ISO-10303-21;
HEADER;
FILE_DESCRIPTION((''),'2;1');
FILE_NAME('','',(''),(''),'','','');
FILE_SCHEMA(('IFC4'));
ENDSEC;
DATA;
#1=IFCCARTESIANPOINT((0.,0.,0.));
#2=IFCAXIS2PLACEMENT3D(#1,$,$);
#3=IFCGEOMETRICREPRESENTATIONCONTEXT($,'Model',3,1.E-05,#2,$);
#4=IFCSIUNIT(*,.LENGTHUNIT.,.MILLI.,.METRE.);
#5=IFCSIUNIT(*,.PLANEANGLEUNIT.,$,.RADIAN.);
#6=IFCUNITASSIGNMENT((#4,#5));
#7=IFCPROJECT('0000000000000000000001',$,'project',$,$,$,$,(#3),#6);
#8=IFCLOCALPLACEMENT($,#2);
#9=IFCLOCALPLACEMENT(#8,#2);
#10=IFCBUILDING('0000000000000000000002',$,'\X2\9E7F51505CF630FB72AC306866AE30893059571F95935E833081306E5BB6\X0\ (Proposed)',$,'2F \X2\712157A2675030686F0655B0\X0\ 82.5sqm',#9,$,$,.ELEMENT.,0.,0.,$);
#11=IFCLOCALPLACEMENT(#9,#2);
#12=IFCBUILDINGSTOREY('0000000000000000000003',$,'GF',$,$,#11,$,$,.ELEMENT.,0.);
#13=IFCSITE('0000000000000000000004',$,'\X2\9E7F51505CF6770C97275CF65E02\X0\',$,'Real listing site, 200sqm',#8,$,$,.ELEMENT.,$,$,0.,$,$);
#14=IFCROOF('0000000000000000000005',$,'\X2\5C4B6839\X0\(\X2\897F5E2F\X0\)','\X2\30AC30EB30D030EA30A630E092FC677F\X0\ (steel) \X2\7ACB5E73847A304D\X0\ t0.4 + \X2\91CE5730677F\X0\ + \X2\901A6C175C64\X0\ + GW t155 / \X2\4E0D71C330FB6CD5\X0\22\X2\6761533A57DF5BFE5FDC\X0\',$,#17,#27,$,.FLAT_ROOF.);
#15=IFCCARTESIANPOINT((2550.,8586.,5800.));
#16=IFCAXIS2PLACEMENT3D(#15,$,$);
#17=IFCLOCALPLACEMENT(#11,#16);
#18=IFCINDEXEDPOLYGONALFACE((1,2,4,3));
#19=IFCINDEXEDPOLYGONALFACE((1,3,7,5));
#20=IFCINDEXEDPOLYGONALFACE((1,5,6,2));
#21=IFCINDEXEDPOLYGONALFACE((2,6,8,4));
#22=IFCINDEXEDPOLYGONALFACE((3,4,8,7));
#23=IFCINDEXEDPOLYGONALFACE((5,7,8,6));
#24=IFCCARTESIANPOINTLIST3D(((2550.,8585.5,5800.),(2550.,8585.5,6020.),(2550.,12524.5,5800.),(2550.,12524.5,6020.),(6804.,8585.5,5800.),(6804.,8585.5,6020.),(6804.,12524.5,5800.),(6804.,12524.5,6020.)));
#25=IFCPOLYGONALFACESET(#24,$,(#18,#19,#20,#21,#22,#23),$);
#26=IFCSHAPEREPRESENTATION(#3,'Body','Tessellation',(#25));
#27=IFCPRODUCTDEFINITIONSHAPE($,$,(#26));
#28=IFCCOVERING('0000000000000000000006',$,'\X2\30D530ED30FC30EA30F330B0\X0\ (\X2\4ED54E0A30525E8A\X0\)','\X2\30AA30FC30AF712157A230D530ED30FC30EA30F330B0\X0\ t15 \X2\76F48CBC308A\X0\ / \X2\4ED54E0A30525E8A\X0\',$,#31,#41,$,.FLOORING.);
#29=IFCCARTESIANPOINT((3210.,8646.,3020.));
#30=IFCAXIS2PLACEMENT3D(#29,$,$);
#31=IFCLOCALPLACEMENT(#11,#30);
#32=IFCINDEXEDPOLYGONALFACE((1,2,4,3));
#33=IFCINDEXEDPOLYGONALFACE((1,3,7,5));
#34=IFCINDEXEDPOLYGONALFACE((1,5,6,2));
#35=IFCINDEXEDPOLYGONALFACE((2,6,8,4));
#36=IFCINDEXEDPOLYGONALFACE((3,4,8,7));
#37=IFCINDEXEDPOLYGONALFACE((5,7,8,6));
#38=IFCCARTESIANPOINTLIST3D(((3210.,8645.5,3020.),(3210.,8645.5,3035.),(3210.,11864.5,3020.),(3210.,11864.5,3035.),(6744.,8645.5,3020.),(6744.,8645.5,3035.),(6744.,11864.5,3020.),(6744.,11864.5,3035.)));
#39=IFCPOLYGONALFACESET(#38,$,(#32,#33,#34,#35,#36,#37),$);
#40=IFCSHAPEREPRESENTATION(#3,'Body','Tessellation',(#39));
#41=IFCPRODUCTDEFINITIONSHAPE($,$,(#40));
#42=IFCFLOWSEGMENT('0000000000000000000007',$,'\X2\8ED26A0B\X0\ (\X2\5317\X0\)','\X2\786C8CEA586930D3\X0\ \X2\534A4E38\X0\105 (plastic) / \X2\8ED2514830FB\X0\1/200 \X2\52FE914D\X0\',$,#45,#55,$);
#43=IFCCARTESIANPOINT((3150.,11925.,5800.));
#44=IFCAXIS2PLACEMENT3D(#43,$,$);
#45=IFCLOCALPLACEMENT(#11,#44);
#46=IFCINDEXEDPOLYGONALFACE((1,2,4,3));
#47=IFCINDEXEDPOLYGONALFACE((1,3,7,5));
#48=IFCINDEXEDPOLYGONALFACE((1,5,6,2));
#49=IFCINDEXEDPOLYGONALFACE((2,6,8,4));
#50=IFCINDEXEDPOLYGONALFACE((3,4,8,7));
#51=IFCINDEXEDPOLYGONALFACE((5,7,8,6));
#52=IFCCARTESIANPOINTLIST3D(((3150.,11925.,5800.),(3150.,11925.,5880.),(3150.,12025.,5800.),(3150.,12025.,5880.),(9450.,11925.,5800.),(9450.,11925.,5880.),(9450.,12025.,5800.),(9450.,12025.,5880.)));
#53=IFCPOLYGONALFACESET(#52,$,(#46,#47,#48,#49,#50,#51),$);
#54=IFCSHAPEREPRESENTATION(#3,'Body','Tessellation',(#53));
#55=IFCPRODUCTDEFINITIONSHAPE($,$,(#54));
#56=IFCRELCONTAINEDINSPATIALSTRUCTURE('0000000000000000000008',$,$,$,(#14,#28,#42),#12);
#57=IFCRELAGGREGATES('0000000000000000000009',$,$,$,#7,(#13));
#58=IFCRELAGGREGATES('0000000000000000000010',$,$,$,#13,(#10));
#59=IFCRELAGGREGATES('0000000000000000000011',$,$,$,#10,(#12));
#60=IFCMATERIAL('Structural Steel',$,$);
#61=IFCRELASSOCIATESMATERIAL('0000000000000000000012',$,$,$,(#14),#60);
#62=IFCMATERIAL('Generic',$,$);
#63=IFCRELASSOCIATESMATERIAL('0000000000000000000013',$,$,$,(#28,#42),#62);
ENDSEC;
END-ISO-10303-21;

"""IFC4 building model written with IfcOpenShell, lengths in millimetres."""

from ifc_helpers import new_model, si_unit, frame, frame_2d, origin, place, context, project, spatial, rectangle, extrude, material, element, save


model = new_model("IFC4")

# Units and contexts
model_context = context("Model", 3, precision=1e-05, world=origin())
ifc_project = project(units=[si_unit("LENGTHUNIT", "METRE", prefix="MILLI"), si_unit("PLANEANGLEUNIT", "RADIAN")], contexts=[model_context])

# Site, building, storey
site_placement = place(None, origin())
site = spatial("IfcSite", under=ifc_project, at=site_placement, Name="鹿児島県霧島市", ObjectType="Real listing site, 200sqm", CompositionType="ELEMENT", RefElevation=0.0)
building_placement = place(site_placement, origin())
building = spatial("IfcBuilding", under=site, at=building_placement, Name="鹿児島・犬と暮らす土間広めの家 (Proposed)", ObjectType="2F 無垢材と漆喰 82.5sqm", CompositionType="ELEMENT", ElevationOfRefHeight=0.0, ElevationOfTerrain=0.0)
storey_placement = place(building_placement, origin())
storey = spatial("IfcBuildingStorey", under=building, at=storey_placement, Name="GF", CompositionType="ELEMENT", Elevation=0.0)

# Roof
ifc_material_1 = material(Name="Structural Steel")
for number, where, name in (
    (1, (2550.0, 8586.0, 5800.0), "屋根(西帯)"),
):
    element("IfcRoof", number, at=place(storey_placement, frame(where)), inside=storey, material=ifc_material_1, Name=name, Description="ガルバリウム鋼板 (steel) 立平葺き t0.4 + 野地板 + 通気層 + GW t155 / 不燃・法22条区域対応", PredefinedType="FLAT_ROOF", context=model_context, shape_type="SweptSolid", body=[
        extrude(rectangle(XDim=4254.0, YDim=3939.0, at=frame_2d((2127.0, 1969.0))), frame((2550.0, 8586.0, 5800.0)), (0.0, 0.0, 1.0), 220.0),
    ])

# Covering
ifc_material_2 = material(Name="Generic")
covering_placement = place(storey_placement, frame((3210.0, 8646.0, 3020.0)))
element("IfcCovering", 2, at=covering_placement, inside=storey, material=ifc_material_2, Name="フローリング (仕上げ床)", Description="オーク無垢フローリング t15 直貼り / 仕上げ床", PredefinedType="FLOORING", context=model_context, shape_type="SweptSolid", body=[
    extrude(rectangle(XDim=3534.0, YDim=3219.0, at=frame_2d((1767.0, 1609.0))), frame((3210.0, 8646.0, 3020.0)), (0.0, 0.0, 1.0), 15.0),
])

# Flow segment
flow_segment_placement = place(storey_placement, frame((3150.0, 11925.0, 5800.0)))
element("IfcFlowSegment", 3, at=flow_segment_placement, inside=storey, material=ifc_material_2, Name="軒樋 (北)", Description="硬質塩ビ 半丸105 (plastic) / 軒先・1/200 勾配", context=model_context, shape_type="SweptSolid", body=[
    extrude(rectangle(XDim=6300.0, YDim=100.0, at=frame_2d((3150.0, 50.0))), frame((3150.0, 11925.0, 5800.0)), (0.0, 0.0, 1.0), 80.0),
])

save(model, "model.ifc")
